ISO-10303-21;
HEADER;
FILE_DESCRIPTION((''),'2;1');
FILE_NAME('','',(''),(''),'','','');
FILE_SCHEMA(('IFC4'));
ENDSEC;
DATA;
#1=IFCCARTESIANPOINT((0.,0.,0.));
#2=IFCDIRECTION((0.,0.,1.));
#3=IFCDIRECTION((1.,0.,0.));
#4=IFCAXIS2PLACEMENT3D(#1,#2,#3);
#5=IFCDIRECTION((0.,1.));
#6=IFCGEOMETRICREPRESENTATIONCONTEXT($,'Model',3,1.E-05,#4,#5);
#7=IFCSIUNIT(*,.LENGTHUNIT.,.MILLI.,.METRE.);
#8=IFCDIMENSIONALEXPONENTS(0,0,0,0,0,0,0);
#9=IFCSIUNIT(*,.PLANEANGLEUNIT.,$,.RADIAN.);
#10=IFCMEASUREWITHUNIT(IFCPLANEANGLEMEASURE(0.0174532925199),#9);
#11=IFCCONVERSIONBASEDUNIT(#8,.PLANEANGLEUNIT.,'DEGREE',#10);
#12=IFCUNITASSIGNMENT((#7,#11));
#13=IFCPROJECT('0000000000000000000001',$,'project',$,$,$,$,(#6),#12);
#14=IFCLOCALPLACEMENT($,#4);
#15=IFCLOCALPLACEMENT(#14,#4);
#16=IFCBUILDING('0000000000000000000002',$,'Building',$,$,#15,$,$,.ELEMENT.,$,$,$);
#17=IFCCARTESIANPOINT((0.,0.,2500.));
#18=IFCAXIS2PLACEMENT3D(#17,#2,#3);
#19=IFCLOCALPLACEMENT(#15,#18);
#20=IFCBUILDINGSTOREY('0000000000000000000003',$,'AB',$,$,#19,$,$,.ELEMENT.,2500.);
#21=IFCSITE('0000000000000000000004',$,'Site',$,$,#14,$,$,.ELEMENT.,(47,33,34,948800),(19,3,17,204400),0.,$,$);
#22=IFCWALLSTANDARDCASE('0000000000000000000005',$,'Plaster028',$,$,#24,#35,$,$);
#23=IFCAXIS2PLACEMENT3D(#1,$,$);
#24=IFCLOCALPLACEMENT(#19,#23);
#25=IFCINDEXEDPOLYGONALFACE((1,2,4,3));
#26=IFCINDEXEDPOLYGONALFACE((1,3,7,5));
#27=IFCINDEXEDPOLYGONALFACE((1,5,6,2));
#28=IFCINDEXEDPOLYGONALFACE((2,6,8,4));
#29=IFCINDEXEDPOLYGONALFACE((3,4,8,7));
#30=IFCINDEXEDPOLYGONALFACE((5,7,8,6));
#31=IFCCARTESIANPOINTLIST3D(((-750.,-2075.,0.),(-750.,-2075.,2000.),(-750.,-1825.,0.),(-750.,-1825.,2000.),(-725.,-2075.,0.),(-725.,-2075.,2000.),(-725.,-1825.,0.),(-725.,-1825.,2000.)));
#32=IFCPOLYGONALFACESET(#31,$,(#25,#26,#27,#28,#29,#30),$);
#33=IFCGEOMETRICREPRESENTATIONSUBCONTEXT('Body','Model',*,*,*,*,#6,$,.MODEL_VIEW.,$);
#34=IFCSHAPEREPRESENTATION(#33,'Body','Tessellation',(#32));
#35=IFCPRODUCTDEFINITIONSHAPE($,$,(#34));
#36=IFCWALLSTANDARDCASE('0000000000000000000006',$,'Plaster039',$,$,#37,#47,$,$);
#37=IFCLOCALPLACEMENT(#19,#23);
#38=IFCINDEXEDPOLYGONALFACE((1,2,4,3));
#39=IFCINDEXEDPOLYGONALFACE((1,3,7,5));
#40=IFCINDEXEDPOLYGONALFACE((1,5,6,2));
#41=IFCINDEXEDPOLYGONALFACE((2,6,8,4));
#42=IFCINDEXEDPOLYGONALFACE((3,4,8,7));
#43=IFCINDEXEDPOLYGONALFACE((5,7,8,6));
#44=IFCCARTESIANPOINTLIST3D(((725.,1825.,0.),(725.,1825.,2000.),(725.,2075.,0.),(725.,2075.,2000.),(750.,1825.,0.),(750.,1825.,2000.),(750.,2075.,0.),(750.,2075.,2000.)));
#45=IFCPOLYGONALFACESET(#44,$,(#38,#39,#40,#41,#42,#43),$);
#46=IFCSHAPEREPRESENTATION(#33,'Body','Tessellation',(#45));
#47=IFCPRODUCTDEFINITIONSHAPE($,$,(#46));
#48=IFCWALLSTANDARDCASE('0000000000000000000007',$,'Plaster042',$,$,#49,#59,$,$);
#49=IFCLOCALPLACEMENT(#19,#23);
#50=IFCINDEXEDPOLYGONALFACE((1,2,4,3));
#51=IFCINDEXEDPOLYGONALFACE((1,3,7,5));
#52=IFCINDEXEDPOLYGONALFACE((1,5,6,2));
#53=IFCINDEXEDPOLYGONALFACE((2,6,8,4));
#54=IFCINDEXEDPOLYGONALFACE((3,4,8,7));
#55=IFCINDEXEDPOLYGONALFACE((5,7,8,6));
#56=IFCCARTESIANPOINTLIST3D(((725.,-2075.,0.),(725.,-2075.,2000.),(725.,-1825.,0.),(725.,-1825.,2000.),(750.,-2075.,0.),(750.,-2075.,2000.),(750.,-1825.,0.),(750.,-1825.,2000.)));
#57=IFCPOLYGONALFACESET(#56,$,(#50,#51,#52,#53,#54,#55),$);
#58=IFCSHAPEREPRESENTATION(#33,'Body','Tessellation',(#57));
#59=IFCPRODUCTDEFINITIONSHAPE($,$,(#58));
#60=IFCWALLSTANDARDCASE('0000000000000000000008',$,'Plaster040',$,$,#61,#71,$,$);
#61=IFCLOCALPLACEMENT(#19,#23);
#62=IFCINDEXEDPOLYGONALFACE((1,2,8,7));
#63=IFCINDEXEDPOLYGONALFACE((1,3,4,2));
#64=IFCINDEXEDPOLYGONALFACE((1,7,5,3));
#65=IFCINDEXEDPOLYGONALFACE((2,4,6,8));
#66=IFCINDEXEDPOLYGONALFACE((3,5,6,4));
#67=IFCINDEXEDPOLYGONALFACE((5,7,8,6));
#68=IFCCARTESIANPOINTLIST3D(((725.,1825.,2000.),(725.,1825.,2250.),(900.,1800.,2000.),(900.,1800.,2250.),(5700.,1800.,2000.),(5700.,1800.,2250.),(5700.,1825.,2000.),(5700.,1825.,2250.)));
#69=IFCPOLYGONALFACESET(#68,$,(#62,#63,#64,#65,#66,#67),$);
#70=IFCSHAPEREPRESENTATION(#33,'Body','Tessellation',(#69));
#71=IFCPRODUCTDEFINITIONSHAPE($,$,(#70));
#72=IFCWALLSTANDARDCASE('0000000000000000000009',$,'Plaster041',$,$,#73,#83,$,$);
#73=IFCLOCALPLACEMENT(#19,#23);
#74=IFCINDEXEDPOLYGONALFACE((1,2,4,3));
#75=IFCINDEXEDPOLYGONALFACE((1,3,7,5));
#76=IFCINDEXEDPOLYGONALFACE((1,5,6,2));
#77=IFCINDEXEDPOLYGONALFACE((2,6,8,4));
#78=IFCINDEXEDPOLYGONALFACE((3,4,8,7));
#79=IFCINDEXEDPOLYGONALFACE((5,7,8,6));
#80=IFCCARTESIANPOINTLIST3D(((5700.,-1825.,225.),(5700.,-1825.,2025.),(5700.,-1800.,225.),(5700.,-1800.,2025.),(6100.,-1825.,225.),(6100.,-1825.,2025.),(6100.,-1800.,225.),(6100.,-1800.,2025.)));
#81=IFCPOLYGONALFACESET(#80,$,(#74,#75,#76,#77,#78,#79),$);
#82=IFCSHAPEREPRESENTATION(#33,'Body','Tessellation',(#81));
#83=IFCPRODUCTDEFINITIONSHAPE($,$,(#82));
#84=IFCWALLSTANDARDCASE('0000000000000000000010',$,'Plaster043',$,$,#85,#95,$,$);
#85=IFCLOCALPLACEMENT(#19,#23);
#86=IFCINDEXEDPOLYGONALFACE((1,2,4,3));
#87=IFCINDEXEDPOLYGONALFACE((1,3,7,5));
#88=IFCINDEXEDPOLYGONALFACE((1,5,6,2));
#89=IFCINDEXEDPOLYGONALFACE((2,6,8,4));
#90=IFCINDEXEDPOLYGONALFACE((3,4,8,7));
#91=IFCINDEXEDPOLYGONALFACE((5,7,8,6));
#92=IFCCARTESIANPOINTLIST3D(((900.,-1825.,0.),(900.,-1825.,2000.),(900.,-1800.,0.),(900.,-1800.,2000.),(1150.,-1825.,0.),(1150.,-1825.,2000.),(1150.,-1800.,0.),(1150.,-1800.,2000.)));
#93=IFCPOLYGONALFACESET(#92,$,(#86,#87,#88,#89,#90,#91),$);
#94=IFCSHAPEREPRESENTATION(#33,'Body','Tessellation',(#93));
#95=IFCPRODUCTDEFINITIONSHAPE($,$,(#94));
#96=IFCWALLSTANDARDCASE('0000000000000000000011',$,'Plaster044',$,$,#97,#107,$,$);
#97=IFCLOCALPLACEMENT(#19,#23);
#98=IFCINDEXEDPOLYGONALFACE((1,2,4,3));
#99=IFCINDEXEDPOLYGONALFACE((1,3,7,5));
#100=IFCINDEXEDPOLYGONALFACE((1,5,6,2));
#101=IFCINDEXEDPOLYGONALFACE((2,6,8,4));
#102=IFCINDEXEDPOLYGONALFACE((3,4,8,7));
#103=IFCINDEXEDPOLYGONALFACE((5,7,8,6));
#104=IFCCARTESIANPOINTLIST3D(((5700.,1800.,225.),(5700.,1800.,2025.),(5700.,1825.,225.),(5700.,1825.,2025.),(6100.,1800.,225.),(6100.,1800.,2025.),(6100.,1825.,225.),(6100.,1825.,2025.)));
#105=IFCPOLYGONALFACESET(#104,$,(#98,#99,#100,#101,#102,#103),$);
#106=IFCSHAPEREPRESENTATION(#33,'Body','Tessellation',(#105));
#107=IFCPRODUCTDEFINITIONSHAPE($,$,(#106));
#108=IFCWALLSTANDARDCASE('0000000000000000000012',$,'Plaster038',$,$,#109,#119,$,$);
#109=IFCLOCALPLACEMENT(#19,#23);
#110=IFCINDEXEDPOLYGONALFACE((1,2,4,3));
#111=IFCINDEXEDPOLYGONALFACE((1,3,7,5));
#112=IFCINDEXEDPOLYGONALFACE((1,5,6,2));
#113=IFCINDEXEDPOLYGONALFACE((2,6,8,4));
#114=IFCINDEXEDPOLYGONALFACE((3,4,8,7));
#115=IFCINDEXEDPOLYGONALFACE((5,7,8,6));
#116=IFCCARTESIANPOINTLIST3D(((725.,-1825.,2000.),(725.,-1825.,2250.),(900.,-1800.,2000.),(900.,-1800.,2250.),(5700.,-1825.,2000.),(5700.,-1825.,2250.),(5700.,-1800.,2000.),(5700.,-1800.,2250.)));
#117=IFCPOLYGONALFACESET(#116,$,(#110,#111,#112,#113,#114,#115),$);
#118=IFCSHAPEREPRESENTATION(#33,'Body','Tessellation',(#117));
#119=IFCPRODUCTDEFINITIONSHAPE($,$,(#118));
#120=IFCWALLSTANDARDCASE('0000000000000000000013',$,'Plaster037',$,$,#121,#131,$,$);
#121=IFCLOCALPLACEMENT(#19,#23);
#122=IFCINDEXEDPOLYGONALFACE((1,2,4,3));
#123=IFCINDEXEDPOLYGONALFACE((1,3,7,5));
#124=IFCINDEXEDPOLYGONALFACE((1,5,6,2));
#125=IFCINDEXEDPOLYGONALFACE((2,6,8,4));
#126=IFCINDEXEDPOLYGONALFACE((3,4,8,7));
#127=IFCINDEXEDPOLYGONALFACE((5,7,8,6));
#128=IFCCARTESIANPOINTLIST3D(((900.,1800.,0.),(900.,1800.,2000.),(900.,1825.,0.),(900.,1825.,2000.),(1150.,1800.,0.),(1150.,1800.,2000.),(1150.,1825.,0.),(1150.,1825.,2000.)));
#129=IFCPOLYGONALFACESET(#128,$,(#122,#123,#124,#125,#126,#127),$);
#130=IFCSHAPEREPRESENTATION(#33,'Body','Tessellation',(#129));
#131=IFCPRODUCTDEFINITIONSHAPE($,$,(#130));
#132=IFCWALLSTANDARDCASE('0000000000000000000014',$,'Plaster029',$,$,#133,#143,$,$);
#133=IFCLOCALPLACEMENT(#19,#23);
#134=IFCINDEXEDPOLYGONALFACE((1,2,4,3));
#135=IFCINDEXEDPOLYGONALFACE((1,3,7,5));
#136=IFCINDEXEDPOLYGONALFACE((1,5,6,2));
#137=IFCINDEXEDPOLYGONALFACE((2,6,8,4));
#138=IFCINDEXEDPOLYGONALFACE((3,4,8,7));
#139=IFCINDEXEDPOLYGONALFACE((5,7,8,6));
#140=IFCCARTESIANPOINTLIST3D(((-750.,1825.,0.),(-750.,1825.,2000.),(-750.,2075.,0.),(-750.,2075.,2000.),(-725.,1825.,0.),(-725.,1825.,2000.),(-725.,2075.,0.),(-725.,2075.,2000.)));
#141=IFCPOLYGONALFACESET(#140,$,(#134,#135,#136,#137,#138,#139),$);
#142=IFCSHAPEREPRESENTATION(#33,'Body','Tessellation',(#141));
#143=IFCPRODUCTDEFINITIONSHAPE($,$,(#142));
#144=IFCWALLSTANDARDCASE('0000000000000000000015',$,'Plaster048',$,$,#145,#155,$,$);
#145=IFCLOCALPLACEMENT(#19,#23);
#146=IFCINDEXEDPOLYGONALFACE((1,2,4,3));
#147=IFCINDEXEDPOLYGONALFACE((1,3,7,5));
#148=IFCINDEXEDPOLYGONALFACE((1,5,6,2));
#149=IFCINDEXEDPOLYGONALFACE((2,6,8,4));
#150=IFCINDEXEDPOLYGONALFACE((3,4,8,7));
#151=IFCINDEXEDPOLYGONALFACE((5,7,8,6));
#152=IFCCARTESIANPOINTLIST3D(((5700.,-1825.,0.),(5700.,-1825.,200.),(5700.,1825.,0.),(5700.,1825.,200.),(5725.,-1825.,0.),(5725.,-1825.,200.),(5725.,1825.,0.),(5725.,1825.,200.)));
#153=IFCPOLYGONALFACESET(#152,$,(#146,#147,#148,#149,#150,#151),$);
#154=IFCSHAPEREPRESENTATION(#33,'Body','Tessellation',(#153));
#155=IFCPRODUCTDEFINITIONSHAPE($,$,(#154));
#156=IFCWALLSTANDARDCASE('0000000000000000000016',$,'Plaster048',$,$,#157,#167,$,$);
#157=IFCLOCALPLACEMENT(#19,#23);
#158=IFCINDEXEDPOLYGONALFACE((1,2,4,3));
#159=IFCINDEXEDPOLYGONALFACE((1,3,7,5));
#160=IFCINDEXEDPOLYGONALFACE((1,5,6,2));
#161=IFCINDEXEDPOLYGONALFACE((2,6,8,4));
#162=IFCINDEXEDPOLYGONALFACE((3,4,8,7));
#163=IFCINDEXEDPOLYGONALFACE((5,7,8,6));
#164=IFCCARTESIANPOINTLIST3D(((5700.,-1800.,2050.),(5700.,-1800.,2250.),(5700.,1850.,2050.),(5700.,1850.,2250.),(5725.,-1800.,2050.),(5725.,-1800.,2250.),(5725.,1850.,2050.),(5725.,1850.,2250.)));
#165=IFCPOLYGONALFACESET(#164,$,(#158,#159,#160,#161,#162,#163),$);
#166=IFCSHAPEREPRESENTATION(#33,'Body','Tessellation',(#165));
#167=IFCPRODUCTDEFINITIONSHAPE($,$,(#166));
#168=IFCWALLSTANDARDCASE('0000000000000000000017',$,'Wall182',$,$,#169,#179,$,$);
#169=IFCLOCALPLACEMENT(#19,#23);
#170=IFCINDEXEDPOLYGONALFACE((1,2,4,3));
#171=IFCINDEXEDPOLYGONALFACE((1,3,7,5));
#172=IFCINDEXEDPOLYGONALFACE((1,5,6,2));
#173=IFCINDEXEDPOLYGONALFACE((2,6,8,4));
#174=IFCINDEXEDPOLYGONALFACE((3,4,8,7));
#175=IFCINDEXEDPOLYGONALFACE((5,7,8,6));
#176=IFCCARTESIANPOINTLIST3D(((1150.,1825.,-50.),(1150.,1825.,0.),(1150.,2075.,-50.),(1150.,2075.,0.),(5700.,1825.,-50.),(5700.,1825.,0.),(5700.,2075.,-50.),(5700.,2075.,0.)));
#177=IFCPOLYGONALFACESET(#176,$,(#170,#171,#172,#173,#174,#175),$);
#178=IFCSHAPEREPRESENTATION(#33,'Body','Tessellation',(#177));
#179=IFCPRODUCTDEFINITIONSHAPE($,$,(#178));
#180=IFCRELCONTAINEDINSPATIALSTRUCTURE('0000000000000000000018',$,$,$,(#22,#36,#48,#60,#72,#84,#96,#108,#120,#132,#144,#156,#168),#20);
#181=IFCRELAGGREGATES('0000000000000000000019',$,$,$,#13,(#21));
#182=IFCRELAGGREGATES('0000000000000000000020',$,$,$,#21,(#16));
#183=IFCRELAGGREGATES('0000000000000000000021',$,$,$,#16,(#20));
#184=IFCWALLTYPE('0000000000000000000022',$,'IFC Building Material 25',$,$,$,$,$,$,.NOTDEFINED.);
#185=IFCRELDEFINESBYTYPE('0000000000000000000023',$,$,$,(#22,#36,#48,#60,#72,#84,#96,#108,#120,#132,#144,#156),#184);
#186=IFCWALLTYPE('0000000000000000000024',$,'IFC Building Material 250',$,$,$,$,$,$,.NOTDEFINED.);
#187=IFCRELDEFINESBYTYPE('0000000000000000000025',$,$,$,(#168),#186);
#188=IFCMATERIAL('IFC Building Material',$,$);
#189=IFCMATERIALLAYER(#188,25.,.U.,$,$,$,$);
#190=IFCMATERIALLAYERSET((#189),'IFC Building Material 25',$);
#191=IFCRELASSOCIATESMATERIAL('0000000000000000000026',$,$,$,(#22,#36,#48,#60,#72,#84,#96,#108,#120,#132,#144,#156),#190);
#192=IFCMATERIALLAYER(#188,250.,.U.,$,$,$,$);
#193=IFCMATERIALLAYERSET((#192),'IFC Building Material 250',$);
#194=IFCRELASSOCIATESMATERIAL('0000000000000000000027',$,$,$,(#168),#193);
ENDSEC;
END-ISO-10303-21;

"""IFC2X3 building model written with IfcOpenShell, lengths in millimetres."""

from ifc_helpers import new_model, entity, si_unit, converted_unit, direction, frame, origin_with_axes, place, context, subcontext, project, spatial, polyline, outline, extrude, material, layer, layer_set, layer_usage, type_object, element, save


model = new_model("IFC2X3")

# Units and contexts
model_context = context("Model", 3, precision=1e-05, world=origin_with_axes(), true_north=direction((0.0, 1.0)))
body_context = subcontext(model_context, "Body", "Model", "MODEL_VIEW")
ifc_project = project(units=[si_unit("LENGTHUNIT", "METRE", prefix="MILLI"), converted_unit("PLANEANGLEUNIT", "DEGREE", entity("IfcPlaneAngleMeasure", 0.0174532925199), si_unit("PLANEANGLEUNIT", "RADIAN"), dimensions=[0, 0, 0, 0, 0, 0, 0])], contexts=[model_context])

# Site, building, storey
site_placement = place(None, origin_with_axes())
site = spatial("IfcSite", under=ifc_project, at=site_placement, Name="Site", CompositionType="ELEMENT", RefLatitude=(47, 33, 34, 948800), RefLongitude=(19, 3, 17, 204400), RefElevation=0.0)
building_placement = place(site_placement, origin_with_axes())
building = spatial("IfcBuilding", under=site, at=building_placement, Name="Building", CompositionType="ELEMENT")
storey_placement = place(building_placement, frame((0.0, 0.0, 2500.0), z_axis=(0.0, 0.0, 1.0), x_axis=(1.0, 0.0, 0.0)))
storey = spatial("IfcBuildingStorey", under=building, at=storey_placement, Name="AB", CompositionType="ELEMENT", Elevation=2500.0)

# Shared definitions
ifc_material = material(Name="IFC Building Material")

# Shared definitions
ifc_layer_1 = layer(ifc_material, 25.0, ventilated="UNKNOWN")
ifc_layer_set_1 = layer_set([ifc_layer_1], Name="IFC Building Material 25")

# Walls
ifc_layer_usage_1 = layer_usage(ifc_layer_set_1, "AXIS2", "POSITIVE", -25.0)
wall_type_1 = type_object("IfcWallType", Name="IFC Building Material 25", PredefinedType="NOTDEFINED")
wall_1_placement = place(storey_placement, frame((-725.0, -1825.0, 0.0), z_axis=(0.0, 0.0, 1.0), x_axis=(0.0, -1.0, 0.0)))
element("IfcWallStandardCase", 1, at=wall_1_placement, inside=storey, type_object=wall_type_1, material=ifc_layer_usage_1, Name="Plaster028", context=body_context, shape_type="SweptSolid", body=[
    extrude(outline(polyline([(0.0, -25.0), (250.0, -25.0), (250.0, 0.0), (0.0, 0.0), (0.0, -25.0)])), origin_with_axes(), (0.0, 0.0, 1.0), 2000.0),
])
ifc_layer_usage_2 = layer_usage(ifc_layer_set_1, "AXIS2", "POSITIVE", -25.0)
wall_2_placement = place(storey_placement, frame((725.0, 1825.0, 0.0), z_axis=(0.0, 0.0, 1.0), x_axis=(0.0, 1.0, 0.0)))
element("IfcWallStandardCase", 2, at=wall_2_placement, inside=storey, type_object=wall_type_1, material=ifc_layer_usage_2, Name="Plaster039", context=body_context, shape_type="SweptSolid", body=[
    extrude(outline(polyline([(0.0, -25.0), (250.0, -25.0), (250.0, 0.0), (0.0, 0.0), (0.0, -25.0)])), origin_with_axes(), (0.0, 0.0, 1.0), 2000.0),
])
ifc_layer_usage_3 = layer_usage(ifc_layer_set_1, "AXIS2", "POSITIVE", 0.0)
wall_3_placement = place(storey_placement, frame((725.0, -1825.0, 0.0), z_axis=(0.0, 0.0, 1.0), x_axis=(0.0, -1.0, 0.0)))
element("IfcWallStandardCase", 3, at=wall_3_placement, inside=storey, type_object=wall_type_1, material=ifc_layer_usage_3, Name="Plaster042", context=body_context, shape_type="SweptSolid", body=[
    extrude(outline(polyline([(0.0, 0.0), (250.0, 0.0), (250.0, 25.0), (0.0, 25.0), (0.0, 0.0)])), origin_with_axes(), (0.0, 0.0, 1.0), 2000.0),
])
ifc_layer_usage_4 = layer_usage(ifc_layer_set_1, "AXIS2", "POSITIVE", -25.0)
wall_4_placement = place(storey_placement, frame((900.0, 1825.0, 2000.0), z_axis=(0.0, 0.0, 1.0), x_axis=(1.0, 0.0, 0.0)))
element("IfcWallStandardCase", 4, at=wall_4_placement, inside=storey, type_object=wall_type_1, material=ifc_layer_usage_4, Name="Plaster040", context=body_context, shape_type="SweptSolid", body=[
    extrude(outline(polyline([(0.0, -25.0), (4800.0, -25.0), (4800.0, 0.0), (-175.0, 0.0), (0.0, -25.0)])), origin_with_axes(), (0.0, 0.0, 1.0), 250.0),
])
ifc_layer_usage_5 = layer_usage(ifc_layer_set_1, "AXIS2", "POSITIVE", 0.0)
wall_5_placement = place(storey_placement, frame((6100.0, -1800.0, 225.0), z_axis=(0.0, 0.0, 1.0), x_axis=(-1.0, 0.0, 0.0)))
element("IfcWallStandardCase", 5, at=wall_5_placement, inside=storey, type_object=wall_type_1, material=ifc_layer_usage_5, Name="Plaster041", context=body_context, shape_type="SweptSolid", body=[
    extrude(outline(polyline([(0.0, 0.0), (400.0, 0.0), (400.0, 25.0), (0.0, 25.0), (0.0, 0.0)])), origin_with_axes(), (0.0, 0.0, 1.0), 1800.0),
])
ifc_layer_usage_6 = layer_usage(ifc_layer_set_1, "AXIS2", "POSITIVE", 0.0)
wall_6_placement = place(storey_placement, frame((1150.0, -1800.0, 0.0), z_axis=(0.0, 0.0, 1.0), x_axis=(-1.0, 0.0, 0.0)))
element("IfcWallStandardCase", 6, at=wall_6_placement, inside=storey, type_object=wall_type_1, material=ifc_layer_usage_6, Name="Plaster043", context=body_context, shape_type="SweptSolid", body=[
    extrude(outline(polyline([(0.0, 0.0), (250.0, 0.0), (250.0, 25.0), (0.0, 25.0), (0.0, 0.0)])), origin_with_axes(), (0.0, 0.0, 1.0), 2000.0),
])
ifc_layer_usage_7 = layer_usage(ifc_layer_set_1, "AXIS2", "POSITIVE", -25.0)
wall_7_placement = place(storey_placement, frame((6100.0, 1800.0, 225.0), z_axis=(0.0, 0.0, 1.0), x_axis=(-1.0, 0.0, 0.0)))
element("IfcWallStandardCase", 7, at=wall_7_placement, inside=storey, type_object=wall_type_1, material=ifc_layer_usage_7, Name="Plaster044", context=body_context, shape_type="SweptSolid", body=[
    extrude(outline(polyline([(0.0, -25.0), (400.0, -25.0), (400.0, 0.0), (0.0, 0.0), (0.0, -25.0)])), origin_with_axes(), (0.0, 0.0, 1.0), 1800.0),
])
ifc_layer_usage_8 = layer_usage(ifc_layer_set_1, "AXIS2", "POSITIVE", 0.0)
wall_8_placement = place(storey_placement, frame((900.0, -1825.0, 2000.0), z_axis=(0.0, 0.0, 1.0), x_axis=(1.0, 0.0, 0.0)))
element("IfcWallStandardCase", 8, at=wall_8_placement, inside=storey, type_object=wall_type_1, material=ifc_layer_usage_8, Name="Plaster038", context=body_context, shape_type="SweptSolid", body=[
    extrude(outline(polyline([(-175.0, 0.0), (4800.0, 0.0), (4800.0, 25.0), (0.0, 25.0), (-175.0, 0.0)])), origin_with_axes(), (0.0, 0.0, 1.0), 250.0),
])
ifc_layer_usage_9 = layer_usage(ifc_layer_set_1, "AXIS2", "POSITIVE", -25.0)
wall_9_placement = place(storey_placement, frame((1150.0, 1800.0, 0.0), z_axis=(0.0, 0.0, 1.0), x_axis=(-1.0, 0.0, 0.0)))
element("IfcWallStandardCase", 9, at=wall_9_placement, inside=storey, type_object=wall_type_1, material=ifc_layer_usage_9, Name="Plaster037", context=body_context, shape_type="SweptSolid", body=[
    extrude(outline(polyline([(0.0, -25.0), (250.0, -25.0), (250.0, 0.0), (0.0, 0.0), (0.0, -25.0)])), origin_with_axes(), (0.0, 0.0, 1.0), 2000.0),
])
ifc_layer_usage_10 = layer_usage(ifc_layer_set_1, "AXIS2", "POSITIVE", 0.0)
wall_10_placement = place(storey_placement, frame((-725.0, 1825.0, 0.0), z_axis=(0.0, 0.0, 1.0), x_axis=(0.0, 1.0, 0.0)))
element("IfcWallStandardCase", 10, at=wall_10_placement, inside=storey, type_object=wall_type_1, material=ifc_layer_usage_10, Name="Plaster029", context=body_context, shape_type="SweptSolid", body=[
    extrude(outline(polyline([(0.0, 0.0), (250.0, 0.0), (250.0, 25.0), (0.0, 25.0), (0.0, 0.0)])), origin_with_axes(), (0.0, 0.0, 1.0), 2000.0),
])
ifc_layer_usage_11 = layer_usage(ifc_layer_set_1, "AXIS2", "POSITIVE", 0.0)
wall_11_placement = place(storey_placement, frame((5725.0, -1825.0, 0.0), z_axis=(0.0, 0.0, 1.0), x_axis=(0.0, 1.0, 0.0)))
element("IfcWallStandardCase", 11, at=wall_11_placement, inside=storey, type_object=wall_type_1, material=ifc_layer_usage_11, Name="Plaster048", context=body_context, shape_type="SweptSolid", body=[
    extrude(outline(polyline([(0.0, 0.0), (3650.0, 0.0), (3650.0, 25.0), (0.0, 25.0), (0.0, 0.0)])), origin_with_axes(), (0.0, 0.0, 1.0), 200.0),
])
ifc_layer_usage_12 = layer_usage(ifc_layer_set_1, "AXIS2", "POSITIVE", 0.0)
wall_12_placement = place(storey_placement, frame((5725.0, -1800.0, 2050.0), z_axis=(0.0, 0.0, 1.0), x_axis=(0.0, 1.0, 0.0)))
element("IfcWallStandardCase", 12, at=wall_12_placement, inside=storey, type_object=wall_type_1, material=ifc_layer_usage_12, Name="Plaster048", context=body_context, shape_type="SweptSolid", body=[
    extrude(outline(polyline([(0.0, 0.0), (3650.0, 0.0), (3650.0, 25.0), (0.0, 25.0), (0.0, 0.0)])), origin_with_axes(), (0.0, 0.0, 1.0), 200.0),
])
ifc_layer_2 = layer(ifc_material, 250.0, ventilated="UNKNOWN")
ifc_layer_set_2 = layer_set([ifc_layer_2], Name="IFC Building Material 250")
ifc_layer_usage_13 = layer_usage(ifc_layer_set_2, "AXIS2", "POSITIVE", -250.0)
wall_type_2 = type_object("IfcWallType", Name="IFC Building Material 250", PredefinedType="NOTDEFINED")
wall_13_placement = place(storey_placement, frame((1150.0, 2075.0, -50.0), z_axis=(0.0, 0.0, 1.0), x_axis=(1.0, 0.0, 0.0)))
element("IfcWallStandardCase", 13, at=wall_13_placement, inside=storey, type_object=wall_type_2, material=ifc_layer_usage_13, Name="Wall182", context=body_context, shape_type="SweptSolid", body=[
    extrude(outline(polyline([(0.0, -250.0), (4550.0, -250.0), (4550.0, 0.0), (0.0, 0.0), (0.0, -250.0)])), origin_with_axes(), (0.0, 0.0, 1.0), 50.0),
])

save(model, "model.ifc")
